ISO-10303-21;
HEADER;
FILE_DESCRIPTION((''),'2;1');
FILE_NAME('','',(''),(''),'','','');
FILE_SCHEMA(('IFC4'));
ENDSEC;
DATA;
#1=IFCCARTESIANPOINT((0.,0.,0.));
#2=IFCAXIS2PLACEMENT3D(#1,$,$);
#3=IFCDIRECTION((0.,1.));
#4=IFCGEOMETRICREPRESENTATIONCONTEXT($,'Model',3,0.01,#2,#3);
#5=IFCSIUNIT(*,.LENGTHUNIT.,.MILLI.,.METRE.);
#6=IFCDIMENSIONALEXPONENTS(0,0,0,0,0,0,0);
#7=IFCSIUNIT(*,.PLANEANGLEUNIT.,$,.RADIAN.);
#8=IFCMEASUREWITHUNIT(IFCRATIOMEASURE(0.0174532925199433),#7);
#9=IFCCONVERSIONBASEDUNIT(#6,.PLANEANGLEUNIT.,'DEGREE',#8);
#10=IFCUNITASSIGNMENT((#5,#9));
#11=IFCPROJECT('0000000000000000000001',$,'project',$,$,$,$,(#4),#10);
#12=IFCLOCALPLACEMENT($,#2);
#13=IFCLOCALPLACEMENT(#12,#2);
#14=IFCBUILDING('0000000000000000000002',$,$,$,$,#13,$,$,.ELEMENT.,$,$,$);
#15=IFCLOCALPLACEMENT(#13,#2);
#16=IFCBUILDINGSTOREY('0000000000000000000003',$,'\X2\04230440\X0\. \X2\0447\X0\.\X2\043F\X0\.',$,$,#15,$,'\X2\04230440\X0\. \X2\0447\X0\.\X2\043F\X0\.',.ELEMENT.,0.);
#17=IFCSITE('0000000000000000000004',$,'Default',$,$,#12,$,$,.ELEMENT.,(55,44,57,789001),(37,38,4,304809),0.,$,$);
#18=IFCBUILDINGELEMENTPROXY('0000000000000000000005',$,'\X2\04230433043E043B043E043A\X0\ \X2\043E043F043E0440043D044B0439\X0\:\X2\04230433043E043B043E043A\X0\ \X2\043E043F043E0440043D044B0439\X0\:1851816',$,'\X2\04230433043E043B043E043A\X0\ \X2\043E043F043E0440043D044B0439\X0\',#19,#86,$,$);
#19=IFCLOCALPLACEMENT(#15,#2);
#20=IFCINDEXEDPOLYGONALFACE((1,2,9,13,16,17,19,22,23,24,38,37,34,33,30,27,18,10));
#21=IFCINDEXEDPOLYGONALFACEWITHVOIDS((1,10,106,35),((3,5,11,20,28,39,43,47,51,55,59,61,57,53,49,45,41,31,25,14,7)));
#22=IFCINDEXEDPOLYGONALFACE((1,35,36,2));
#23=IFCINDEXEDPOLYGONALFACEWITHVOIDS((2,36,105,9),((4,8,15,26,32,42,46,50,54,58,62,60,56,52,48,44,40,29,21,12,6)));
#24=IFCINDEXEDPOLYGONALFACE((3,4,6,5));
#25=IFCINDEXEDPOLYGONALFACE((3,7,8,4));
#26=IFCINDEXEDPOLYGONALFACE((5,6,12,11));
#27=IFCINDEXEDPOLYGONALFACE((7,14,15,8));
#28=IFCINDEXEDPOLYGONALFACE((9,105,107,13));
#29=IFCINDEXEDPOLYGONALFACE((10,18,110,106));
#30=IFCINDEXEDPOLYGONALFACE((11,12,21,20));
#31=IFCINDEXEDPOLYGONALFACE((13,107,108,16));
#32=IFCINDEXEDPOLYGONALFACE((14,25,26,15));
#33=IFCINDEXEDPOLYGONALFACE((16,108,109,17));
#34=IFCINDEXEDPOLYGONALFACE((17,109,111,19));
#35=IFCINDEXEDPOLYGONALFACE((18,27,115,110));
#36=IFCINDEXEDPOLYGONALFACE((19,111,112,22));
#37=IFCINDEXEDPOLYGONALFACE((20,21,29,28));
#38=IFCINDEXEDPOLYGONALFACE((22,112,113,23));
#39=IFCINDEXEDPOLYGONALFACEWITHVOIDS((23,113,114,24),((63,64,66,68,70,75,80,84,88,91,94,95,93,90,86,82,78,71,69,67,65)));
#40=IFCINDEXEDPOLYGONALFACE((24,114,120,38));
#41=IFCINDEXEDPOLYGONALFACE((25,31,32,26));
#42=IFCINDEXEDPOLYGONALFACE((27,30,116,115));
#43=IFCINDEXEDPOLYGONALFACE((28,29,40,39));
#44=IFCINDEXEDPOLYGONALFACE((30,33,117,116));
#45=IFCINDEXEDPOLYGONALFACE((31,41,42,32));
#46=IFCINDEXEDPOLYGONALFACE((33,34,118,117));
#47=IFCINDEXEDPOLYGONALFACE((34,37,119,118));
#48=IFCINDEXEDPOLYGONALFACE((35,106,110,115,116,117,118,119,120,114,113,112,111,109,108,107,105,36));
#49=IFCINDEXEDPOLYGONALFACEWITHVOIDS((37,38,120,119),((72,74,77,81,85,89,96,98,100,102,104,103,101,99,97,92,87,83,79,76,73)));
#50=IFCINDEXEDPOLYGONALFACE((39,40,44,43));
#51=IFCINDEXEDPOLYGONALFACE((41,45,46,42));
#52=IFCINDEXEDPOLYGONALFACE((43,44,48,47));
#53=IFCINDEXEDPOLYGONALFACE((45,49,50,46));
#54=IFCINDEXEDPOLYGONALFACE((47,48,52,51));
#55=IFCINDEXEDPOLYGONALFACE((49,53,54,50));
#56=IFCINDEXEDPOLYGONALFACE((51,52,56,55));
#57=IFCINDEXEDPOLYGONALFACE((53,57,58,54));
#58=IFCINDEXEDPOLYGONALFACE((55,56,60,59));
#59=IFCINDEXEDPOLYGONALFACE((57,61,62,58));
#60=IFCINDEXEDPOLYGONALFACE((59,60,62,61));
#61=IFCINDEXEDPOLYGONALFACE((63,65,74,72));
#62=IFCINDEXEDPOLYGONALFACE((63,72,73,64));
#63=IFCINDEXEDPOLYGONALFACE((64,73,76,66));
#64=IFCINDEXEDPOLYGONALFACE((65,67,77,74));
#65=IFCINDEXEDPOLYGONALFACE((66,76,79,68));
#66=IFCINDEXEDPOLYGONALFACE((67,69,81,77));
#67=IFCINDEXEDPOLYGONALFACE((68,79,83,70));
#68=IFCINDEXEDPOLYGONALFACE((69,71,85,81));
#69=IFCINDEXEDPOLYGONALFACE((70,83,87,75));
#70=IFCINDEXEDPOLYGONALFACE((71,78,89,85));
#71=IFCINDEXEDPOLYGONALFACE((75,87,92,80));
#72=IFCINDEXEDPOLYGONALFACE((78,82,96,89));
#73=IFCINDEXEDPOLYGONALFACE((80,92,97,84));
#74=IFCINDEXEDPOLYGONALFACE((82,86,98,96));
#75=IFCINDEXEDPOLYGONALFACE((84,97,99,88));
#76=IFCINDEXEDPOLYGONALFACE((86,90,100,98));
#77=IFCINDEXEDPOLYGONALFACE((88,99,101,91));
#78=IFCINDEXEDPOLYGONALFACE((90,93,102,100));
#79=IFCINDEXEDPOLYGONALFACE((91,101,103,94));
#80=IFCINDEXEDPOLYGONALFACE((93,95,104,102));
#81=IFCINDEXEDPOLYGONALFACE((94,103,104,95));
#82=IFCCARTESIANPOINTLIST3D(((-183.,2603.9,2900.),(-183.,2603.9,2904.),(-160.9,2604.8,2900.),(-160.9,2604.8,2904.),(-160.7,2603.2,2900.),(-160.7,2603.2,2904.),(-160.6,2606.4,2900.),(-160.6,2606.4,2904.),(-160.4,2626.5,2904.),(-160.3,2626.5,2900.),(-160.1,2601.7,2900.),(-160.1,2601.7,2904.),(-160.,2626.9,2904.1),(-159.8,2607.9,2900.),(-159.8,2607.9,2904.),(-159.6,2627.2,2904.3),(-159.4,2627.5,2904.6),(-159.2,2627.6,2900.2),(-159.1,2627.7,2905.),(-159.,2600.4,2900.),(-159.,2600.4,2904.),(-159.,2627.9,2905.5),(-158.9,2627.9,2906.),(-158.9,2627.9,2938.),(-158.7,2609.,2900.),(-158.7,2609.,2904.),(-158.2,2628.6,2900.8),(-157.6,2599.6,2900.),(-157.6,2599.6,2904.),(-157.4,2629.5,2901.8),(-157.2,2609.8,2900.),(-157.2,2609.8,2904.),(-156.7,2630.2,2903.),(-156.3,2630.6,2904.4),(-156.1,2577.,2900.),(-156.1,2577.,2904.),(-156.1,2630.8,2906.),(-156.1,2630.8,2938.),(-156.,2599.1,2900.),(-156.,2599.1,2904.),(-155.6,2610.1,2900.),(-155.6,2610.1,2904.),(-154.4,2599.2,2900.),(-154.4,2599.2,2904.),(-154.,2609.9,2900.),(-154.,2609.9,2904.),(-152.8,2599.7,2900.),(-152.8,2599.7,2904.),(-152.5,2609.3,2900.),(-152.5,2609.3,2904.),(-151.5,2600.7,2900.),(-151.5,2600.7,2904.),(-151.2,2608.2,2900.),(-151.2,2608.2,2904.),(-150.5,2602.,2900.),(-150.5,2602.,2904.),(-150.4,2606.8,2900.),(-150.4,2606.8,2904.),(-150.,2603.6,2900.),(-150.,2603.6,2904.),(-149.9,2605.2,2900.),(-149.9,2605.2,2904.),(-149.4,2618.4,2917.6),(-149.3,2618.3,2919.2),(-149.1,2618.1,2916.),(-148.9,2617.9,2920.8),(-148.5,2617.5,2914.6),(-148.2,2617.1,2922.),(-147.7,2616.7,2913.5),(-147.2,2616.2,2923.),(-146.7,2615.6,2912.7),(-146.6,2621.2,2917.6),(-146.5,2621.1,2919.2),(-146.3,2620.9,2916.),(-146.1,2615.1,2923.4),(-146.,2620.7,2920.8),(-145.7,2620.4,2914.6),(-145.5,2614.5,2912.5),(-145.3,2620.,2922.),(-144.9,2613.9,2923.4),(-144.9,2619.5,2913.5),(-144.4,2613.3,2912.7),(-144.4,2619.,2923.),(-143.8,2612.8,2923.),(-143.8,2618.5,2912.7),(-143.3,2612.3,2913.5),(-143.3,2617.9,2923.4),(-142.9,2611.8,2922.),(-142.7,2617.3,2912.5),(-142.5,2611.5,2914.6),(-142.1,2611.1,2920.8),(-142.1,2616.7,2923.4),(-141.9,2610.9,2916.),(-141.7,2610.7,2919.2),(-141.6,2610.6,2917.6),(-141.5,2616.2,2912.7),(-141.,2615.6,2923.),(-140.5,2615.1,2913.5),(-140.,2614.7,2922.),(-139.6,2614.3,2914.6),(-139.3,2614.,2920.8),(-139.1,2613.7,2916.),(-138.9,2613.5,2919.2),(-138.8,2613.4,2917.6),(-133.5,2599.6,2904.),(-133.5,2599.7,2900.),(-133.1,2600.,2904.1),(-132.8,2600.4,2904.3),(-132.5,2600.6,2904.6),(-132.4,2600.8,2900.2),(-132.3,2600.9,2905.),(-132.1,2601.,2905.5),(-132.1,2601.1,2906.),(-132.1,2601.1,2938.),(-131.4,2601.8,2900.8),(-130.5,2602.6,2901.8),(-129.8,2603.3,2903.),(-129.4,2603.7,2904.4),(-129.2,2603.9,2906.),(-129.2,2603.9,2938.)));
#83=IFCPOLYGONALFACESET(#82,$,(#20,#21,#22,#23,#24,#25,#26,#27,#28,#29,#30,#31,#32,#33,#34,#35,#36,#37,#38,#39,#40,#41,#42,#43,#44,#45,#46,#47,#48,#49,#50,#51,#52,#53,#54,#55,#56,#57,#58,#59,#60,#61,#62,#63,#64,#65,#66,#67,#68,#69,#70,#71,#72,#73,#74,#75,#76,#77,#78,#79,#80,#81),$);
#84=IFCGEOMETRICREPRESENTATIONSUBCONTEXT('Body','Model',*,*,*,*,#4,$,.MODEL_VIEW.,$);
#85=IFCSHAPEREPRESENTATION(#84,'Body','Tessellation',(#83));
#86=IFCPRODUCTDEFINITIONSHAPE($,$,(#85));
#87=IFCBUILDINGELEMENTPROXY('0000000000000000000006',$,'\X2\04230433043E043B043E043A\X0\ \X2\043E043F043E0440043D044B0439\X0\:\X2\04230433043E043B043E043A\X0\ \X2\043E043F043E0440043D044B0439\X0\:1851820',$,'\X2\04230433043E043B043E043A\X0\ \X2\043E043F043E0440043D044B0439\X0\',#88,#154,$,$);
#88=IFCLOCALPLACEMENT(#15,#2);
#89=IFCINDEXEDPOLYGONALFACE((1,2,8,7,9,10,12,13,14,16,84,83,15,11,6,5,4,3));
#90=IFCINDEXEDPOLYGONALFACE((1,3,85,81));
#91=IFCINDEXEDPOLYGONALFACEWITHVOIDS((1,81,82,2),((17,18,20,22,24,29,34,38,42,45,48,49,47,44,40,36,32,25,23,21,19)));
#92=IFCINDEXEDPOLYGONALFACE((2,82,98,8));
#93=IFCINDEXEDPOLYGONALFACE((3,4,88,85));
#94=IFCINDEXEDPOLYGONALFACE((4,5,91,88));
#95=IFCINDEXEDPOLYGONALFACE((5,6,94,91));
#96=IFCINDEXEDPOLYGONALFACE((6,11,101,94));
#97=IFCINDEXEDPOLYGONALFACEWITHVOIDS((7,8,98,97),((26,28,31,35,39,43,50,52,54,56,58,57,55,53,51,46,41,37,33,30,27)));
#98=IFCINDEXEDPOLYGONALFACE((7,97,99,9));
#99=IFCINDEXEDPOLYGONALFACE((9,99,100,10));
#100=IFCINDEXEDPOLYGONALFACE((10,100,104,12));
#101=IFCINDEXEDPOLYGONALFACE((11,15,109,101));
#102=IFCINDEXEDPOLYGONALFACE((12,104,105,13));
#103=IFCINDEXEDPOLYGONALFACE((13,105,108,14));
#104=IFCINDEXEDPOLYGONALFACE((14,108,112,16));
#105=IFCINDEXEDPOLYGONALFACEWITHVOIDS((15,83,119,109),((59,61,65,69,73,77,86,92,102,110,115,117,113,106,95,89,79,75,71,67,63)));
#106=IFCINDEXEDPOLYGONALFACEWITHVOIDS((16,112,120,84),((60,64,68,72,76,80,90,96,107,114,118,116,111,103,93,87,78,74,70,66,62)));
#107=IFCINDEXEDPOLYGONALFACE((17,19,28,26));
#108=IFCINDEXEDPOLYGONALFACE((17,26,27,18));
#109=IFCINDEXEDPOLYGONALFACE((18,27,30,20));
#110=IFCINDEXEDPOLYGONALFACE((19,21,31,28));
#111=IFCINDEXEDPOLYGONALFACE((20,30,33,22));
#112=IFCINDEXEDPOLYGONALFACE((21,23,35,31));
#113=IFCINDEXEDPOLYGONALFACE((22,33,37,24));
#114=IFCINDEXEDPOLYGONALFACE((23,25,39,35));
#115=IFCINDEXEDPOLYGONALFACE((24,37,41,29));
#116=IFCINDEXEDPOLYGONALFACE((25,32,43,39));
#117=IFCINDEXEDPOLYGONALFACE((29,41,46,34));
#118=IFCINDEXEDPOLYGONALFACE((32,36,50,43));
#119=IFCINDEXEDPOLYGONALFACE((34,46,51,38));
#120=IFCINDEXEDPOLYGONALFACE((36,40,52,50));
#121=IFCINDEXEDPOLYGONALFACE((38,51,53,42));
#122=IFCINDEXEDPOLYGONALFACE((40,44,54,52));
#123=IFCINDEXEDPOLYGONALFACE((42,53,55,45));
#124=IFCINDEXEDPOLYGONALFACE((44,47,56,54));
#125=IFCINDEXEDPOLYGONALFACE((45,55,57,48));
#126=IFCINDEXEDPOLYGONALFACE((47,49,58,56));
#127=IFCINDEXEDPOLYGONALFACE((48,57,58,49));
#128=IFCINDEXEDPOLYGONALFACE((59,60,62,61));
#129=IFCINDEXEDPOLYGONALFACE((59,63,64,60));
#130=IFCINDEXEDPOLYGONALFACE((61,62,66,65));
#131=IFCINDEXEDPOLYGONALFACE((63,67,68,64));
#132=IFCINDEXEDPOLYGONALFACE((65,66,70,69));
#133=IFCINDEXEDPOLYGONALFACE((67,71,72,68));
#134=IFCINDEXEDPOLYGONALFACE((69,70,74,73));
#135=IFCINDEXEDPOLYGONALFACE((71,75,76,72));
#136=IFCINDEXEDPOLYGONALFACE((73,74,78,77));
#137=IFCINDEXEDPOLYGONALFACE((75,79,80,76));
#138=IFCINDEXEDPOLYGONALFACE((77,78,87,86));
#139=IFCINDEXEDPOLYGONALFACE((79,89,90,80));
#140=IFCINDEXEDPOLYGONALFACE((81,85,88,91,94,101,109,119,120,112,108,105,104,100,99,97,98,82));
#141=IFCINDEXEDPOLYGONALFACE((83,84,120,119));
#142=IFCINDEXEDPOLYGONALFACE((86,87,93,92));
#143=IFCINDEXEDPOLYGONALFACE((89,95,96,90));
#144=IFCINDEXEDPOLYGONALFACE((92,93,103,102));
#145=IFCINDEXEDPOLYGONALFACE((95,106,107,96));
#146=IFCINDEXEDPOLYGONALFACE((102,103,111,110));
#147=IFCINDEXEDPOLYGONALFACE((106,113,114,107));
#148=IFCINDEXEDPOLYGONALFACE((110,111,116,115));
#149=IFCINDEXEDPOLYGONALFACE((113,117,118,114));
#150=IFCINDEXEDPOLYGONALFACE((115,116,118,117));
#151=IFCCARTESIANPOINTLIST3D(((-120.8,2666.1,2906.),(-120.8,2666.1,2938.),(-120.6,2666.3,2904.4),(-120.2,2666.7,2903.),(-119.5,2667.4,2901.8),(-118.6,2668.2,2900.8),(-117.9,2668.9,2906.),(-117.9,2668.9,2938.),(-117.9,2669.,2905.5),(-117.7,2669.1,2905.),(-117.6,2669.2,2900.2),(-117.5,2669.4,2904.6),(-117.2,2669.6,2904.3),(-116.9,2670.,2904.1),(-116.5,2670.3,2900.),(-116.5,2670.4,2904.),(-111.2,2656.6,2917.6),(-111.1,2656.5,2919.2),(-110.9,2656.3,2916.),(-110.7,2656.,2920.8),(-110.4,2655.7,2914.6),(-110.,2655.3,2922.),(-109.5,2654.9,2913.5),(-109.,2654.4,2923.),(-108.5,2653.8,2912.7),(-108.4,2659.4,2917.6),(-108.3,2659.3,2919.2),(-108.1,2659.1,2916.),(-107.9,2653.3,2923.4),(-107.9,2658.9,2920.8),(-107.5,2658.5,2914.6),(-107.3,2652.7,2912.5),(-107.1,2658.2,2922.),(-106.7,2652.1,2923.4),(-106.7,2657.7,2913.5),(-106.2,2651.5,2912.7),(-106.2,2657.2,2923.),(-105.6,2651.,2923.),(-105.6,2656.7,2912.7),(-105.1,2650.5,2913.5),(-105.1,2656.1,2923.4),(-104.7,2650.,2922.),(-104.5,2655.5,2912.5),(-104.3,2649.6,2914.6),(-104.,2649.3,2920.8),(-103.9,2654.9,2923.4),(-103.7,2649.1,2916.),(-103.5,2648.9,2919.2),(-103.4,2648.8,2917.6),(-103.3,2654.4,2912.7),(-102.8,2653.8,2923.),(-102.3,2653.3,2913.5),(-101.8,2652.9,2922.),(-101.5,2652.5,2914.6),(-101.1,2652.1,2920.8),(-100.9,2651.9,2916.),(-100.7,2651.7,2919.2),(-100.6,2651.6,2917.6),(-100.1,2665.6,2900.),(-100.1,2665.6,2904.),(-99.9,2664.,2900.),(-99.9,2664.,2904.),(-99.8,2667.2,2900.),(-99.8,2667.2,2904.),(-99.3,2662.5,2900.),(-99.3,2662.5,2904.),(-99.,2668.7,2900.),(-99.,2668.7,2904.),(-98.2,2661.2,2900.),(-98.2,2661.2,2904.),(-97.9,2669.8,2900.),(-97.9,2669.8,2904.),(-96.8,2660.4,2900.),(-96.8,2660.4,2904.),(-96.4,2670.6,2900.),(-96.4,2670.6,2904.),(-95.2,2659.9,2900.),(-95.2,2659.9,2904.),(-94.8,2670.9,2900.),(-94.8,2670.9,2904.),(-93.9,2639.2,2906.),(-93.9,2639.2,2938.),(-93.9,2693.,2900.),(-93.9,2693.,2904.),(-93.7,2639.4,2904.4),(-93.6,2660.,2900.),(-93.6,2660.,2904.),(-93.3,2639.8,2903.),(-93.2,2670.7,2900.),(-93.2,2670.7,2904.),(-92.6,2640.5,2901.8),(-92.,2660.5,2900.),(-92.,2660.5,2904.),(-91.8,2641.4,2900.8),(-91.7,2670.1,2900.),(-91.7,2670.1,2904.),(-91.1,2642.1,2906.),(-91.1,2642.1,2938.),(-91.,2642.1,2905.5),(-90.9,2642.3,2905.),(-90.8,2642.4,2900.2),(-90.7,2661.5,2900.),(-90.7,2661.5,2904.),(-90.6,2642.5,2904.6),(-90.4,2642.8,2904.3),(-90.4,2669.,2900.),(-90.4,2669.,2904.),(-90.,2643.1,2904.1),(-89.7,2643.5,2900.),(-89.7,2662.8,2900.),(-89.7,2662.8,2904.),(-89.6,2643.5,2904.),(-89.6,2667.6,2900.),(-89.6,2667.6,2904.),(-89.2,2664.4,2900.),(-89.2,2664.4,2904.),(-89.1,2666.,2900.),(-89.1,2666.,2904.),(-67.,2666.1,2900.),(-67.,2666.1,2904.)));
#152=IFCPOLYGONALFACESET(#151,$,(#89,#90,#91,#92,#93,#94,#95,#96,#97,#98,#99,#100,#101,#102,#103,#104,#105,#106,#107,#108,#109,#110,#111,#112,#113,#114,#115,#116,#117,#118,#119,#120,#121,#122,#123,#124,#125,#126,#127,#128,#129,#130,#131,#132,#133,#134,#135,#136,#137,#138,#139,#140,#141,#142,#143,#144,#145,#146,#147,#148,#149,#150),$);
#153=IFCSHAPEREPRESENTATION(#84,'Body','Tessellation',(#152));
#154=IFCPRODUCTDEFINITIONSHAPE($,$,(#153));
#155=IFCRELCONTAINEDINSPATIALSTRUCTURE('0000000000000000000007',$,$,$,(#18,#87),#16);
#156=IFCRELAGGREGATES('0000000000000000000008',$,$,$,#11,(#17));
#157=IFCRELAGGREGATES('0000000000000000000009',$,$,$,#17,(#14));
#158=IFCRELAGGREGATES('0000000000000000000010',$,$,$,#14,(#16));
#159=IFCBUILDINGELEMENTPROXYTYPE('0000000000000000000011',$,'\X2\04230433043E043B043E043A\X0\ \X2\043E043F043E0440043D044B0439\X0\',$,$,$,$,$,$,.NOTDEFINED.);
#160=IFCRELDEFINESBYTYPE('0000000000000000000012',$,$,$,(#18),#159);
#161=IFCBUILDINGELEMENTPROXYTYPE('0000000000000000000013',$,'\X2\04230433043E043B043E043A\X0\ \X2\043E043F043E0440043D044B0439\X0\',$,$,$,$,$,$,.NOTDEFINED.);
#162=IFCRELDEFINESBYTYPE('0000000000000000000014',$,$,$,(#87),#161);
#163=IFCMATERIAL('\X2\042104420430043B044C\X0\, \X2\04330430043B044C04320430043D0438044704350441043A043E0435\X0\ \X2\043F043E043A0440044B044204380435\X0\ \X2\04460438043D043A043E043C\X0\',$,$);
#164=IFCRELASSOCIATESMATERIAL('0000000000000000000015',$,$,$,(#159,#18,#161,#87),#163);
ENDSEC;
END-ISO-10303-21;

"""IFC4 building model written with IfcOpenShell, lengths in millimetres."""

from ifc_helpers import new_model, entity, si_unit, converted_unit, direction, frame, frame_2d, origin, place, context, subcontext, project, spatial, polyline, circle_curve, parameter, trimmed, segment, composite_curve, circle, outline, extrude, source, transform, mapped, material, type_object, type_shapes, element, save


model = new_model("IFC4")

# Units and contexts
model_context = context("Model", 3, precision=0.01, world=origin(), true_north=direction((0.0, 1.0)))
body_context = subcontext(model_context, "Body", "Model", "MODEL_VIEW")
ifc_project = project(units=[si_unit("LENGTHUNIT", "METRE", prefix="MILLI"), converted_unit("PLANEANGLEUNIT", "DEGREE", entity("IfcRatioMeasure", 0.0174532925199433), si_unit("PLANEANGLEUNIT", "RADIAN"), dimensions=[0, 0, 0, 0, 0, 0, 0])], contexts=[model_context])

# Site, building, storey
site_placement = place(None, origin())
site = spatial("IfcSite", under=ifc_project, at=site_placement, Name="Default", CompositionType="ELEMENT", RefLatitude=(55, 44, 57, 789001), RefLongitude=(37, 38, 4, 304809), RefElevation=0.0)
building_placement = place(site_placement, origin())
building = spatial("IfcBuilding", under=site, at=building_placement, CompositionType="ELEMENT")
storey_placement = place(building_placement, origin())
storey = spatial("IfcBuildingStorey", under=building, at=storey_placement, Name="Ур. ч.п.", LongName="Ур. ч.п.", CompositionType="ELEMENT", Elevation=0.0)

# Building element proxies, openings
ifc_material_1 = material(Name="Сталь, гальваническое покрытие цинком")
building_element_proxy_type_1 = type_object("IfcBuildingElementProxyType", Name="Уголок опорный", material=ifc_material_1)
shared_shape_1 = source(origin(), body_context, "Body", "SweptSolid", [
    extrude(outline(composite_curve([segment(polyline([(-6.0, -12.0), (26.0, -12.0)]), True, "CONTINUOUS"), segment(polyline([(26.0, -12.0), (26.0, -8.0)]), True, "CONTINUOUS"), segment(polyline([(26.0, -8.0), (-6.0, -8.0)]), True, "CONTINUOUS"), segment(trimmed(circle_curve(frame_2d((-6.0, -6.0), x_axis=(0.0, -1.0)), 2.0), [parameter(270.0)], [parameter(0.0)], True, "PARAMETER"), False, "CONTINUOUS"), segment(polyline([(-8.0, -6.0), (-8.0, 26.0)]), True, "CONTINUOUS"), segment(polyline([(-8.0, 26.0), (-12.0, 26.0)]), True, "CONTINUOUS"), segment(polyline([(-12.0, 26.0), (-12.0, -6.0)]), True, "CONTINUOUS"), segment(trimmed(circle_curve(frame_2d((-6.0, -6.0), x_axis=(0.0, -1.0)), 6.0), [parameter(270.0)], [parameter(360.0)], True, "PARAMETER"), True, "CONTINUOUS")], self_intersect=False)), frame((12.0, -19.0, 12.0), z_axis=(0.0, 1.0, 0.0), x_axis=(0.0, 0.0, 1.0)), (0.0, 0.0, 1.0), 38.0),
])
type_shapes(building_element_proxy_type_1, [shared_shape_1])
proxy_1_placement = place(storey_placement, frame((-142.7, 2617.3, 2900.0), z_axis=(0.0, 0.0, 1.0), x_axis=(-0.707107, -0.707107, 0.0)))
proxy_1 = element("IfcBuildingElementProxy", 1, at=proxy_1_placement, inside=storey, type_object=building_element_proxy_type_1, material=ifc_material_1, Name="Уголок опорный:Уголок опорный:1851816", ObjectType="Уголок опорный", context=body_context, shape_type="MappedRepresentation", body=[
    mapped(shared_shape_1, transform((0.0, 0.0, 0.0), scale=1.0)),
])
opening_1_placement = place(storey_placement, frame((-142.7, 2617.3, 2900.0), z_axis=(0.0, 0.0, 1.0), x_axis=(0.0, 1.0, 0.0)))
element("IfcOpeningElement", 2, at=opening_1_placement, cuts=proxy_1, ObjectType="Opening", PredefinedType="OPENING", context=body_context, shape_type="SweptSolid", body=[
    extrude(circle(Radius=5.5, at=frame_2d((0.0, 0.0), x_axis=(1.0, 0.0))), frame((-2.8, 2.8, 18.0), z_axis=(0.707107, -0.707107, 0.0), x_axis=(0.0, 0.0, -1.0)), (0.0, 0.0, 1.0), 4.0),
])
opening_2_placement = place(storey_placement, frame((-142.7, 2617.3, 2900.0), z_axis=(0.0, 0.0, 1.0), x_axis=(0.0, 1.0, 0.0)))
element("IfcOpeningElement", 3, at=opening_2_placement, cuts=proxy_1, ObjectType="Opening", PredefinedType="OPENING", context=body_context, shape_type="SweptSolid", body=[
    extrude(circle(Radius=5.5, at=frame_2d((0.0, 0.0), x_axis=(1.0, 0.0))), frame((-12.7, 12.7, 0.0), z_axis=(0.0, 0.0, 1.0), x_axis=(-0.707107, -0.707107, 0.0)), (0.0, 0.0, 1.0), 4.0),
])
building_element_proxy_type_2 = type_object("IfcBuildingElementProxyType", Name="Уголок опорный", material=ifc_material_1)
shared_shape_2 = source(origin(), body_context, "Body", "SweptSolid", [
    extrude(outline(composite_curve([segment(polyline([(-6.0, -12.0), (26.0, -12.0)]), True, "CONTINUOUS"), segment(polyline([(26.0, -12.0), (26.0, -8.0)]), True, "CONTINUOUS"), segment(polyline([(26.0, -8.0), (-6.0, -8.0)]), True, "CONTINUOUS"), segment(trimmed(circle_curve(frame_2d((-6.0, -6.0), x_axis=(0.0, -1.0)), 2.0), [parameter(270.0)], [parameter(0.0)], True, "PARAMETER"), False, "CONTINUOUS"), segment(polyline([(-8.0, -6.0), (-8.0, 26.0)]), True, "CONTINUOUS"), segment(polyline([(-8.0, 26.0), (-12.0, 26.0)]), True, "CONTINUOUS"), segment(polyline([(-12.0, 26.0), (-12.0, -6.0)]), True, "CONTINUOUS"), segment(trimmed(circle_curve(frame_2d((-6.0, -6.0), x_axis=(0.0, -1.0)), 6.0), [parameter(270.0)], [parameter(360.0)], True, "PARAMETER"), True, "CONTINUOUS")], self_intersect=False)), frame((12.0, -19.0, 12.0), z_axis=(0.0, 1.0, 0.0), x_axis=(0.0, 0.0, 1.0)), (0.0, 0.0, 1.0), 38.0),
])
type_shapes(building_element_proxy_type_2, [shared_shape_2])
proxy_2_placement = place(storey_placement, frame((-107.3, 2652.7, 2900.0), z_axis=(0.0, 0.0, 1.0), x_axis=(0.707107, 0.707107, 0.0)))
proxy_2 = element("IfcBuildingElementProxy", 4, at=proxy_2_placement, inside=storey, type_object=building_element_proxy_type_2, material=ifc_material_1, Name="Уголок опорный:Уголок опорный:1851820", ObjectType="Уголок опорный", context=body_context, shape_type="MappedRepresentation", body=[
    mapped(shared_shape_2, transform((0.0, 0.0, 0.0), scale=1.0)),
])
opening_3_placement = place(storey_placement, frame((-107.3, 2652.7, 2900.0), z_axis=(0.0, 0.0, 1.0), x_axis=(0.0, 1.0, 0.0)))
element("IfcOpeningElement", 5, at=opening_3_placement, cuts=proxy_2, ObjectType="Opening", PredefinedType="OPENING", context=body_context, shape_type="SweptSolid", body=[
    extrude(circle(Radius=5.5, at=frame_2d((0.0, 0.0), x_axis=(1.0, 0.0))), frame((0.0, 0.0, 18.0), z_axis=(0.707107, -0.707107, 0.0), x_axis=(0.0, 0.0, -1.0)), (0.0, 0.0, 1.0), 4.0),
])
opening_4_placement = place(storey_placement, frame((-107.3, 2652.7, 2900.0), z_axis=(0.0, 0.0, 1.0), x_axis=(0.0, 1.0, 0.0)))
element("IfcOpeningElement", 6, at=opening_4_placement, cuts=proxy_2, ObjectType="Opening", PredefinedType="OPENING", context=body_context, shape_type="SweptSolid", body=[
    extrude(circle(Radius=5.5, at=frame_2d((0.0, 0.0), x_axis=(1.0, 0.0))), frame((12.7, -12.7, 0.0), z_axis=(0.0, 0.0, 1.0), x_axis=(-0.707107, -0.707107, 0.0)), (0.0, 0.0, 1.0), 4.0),
])

save(model, "model.ifc")
